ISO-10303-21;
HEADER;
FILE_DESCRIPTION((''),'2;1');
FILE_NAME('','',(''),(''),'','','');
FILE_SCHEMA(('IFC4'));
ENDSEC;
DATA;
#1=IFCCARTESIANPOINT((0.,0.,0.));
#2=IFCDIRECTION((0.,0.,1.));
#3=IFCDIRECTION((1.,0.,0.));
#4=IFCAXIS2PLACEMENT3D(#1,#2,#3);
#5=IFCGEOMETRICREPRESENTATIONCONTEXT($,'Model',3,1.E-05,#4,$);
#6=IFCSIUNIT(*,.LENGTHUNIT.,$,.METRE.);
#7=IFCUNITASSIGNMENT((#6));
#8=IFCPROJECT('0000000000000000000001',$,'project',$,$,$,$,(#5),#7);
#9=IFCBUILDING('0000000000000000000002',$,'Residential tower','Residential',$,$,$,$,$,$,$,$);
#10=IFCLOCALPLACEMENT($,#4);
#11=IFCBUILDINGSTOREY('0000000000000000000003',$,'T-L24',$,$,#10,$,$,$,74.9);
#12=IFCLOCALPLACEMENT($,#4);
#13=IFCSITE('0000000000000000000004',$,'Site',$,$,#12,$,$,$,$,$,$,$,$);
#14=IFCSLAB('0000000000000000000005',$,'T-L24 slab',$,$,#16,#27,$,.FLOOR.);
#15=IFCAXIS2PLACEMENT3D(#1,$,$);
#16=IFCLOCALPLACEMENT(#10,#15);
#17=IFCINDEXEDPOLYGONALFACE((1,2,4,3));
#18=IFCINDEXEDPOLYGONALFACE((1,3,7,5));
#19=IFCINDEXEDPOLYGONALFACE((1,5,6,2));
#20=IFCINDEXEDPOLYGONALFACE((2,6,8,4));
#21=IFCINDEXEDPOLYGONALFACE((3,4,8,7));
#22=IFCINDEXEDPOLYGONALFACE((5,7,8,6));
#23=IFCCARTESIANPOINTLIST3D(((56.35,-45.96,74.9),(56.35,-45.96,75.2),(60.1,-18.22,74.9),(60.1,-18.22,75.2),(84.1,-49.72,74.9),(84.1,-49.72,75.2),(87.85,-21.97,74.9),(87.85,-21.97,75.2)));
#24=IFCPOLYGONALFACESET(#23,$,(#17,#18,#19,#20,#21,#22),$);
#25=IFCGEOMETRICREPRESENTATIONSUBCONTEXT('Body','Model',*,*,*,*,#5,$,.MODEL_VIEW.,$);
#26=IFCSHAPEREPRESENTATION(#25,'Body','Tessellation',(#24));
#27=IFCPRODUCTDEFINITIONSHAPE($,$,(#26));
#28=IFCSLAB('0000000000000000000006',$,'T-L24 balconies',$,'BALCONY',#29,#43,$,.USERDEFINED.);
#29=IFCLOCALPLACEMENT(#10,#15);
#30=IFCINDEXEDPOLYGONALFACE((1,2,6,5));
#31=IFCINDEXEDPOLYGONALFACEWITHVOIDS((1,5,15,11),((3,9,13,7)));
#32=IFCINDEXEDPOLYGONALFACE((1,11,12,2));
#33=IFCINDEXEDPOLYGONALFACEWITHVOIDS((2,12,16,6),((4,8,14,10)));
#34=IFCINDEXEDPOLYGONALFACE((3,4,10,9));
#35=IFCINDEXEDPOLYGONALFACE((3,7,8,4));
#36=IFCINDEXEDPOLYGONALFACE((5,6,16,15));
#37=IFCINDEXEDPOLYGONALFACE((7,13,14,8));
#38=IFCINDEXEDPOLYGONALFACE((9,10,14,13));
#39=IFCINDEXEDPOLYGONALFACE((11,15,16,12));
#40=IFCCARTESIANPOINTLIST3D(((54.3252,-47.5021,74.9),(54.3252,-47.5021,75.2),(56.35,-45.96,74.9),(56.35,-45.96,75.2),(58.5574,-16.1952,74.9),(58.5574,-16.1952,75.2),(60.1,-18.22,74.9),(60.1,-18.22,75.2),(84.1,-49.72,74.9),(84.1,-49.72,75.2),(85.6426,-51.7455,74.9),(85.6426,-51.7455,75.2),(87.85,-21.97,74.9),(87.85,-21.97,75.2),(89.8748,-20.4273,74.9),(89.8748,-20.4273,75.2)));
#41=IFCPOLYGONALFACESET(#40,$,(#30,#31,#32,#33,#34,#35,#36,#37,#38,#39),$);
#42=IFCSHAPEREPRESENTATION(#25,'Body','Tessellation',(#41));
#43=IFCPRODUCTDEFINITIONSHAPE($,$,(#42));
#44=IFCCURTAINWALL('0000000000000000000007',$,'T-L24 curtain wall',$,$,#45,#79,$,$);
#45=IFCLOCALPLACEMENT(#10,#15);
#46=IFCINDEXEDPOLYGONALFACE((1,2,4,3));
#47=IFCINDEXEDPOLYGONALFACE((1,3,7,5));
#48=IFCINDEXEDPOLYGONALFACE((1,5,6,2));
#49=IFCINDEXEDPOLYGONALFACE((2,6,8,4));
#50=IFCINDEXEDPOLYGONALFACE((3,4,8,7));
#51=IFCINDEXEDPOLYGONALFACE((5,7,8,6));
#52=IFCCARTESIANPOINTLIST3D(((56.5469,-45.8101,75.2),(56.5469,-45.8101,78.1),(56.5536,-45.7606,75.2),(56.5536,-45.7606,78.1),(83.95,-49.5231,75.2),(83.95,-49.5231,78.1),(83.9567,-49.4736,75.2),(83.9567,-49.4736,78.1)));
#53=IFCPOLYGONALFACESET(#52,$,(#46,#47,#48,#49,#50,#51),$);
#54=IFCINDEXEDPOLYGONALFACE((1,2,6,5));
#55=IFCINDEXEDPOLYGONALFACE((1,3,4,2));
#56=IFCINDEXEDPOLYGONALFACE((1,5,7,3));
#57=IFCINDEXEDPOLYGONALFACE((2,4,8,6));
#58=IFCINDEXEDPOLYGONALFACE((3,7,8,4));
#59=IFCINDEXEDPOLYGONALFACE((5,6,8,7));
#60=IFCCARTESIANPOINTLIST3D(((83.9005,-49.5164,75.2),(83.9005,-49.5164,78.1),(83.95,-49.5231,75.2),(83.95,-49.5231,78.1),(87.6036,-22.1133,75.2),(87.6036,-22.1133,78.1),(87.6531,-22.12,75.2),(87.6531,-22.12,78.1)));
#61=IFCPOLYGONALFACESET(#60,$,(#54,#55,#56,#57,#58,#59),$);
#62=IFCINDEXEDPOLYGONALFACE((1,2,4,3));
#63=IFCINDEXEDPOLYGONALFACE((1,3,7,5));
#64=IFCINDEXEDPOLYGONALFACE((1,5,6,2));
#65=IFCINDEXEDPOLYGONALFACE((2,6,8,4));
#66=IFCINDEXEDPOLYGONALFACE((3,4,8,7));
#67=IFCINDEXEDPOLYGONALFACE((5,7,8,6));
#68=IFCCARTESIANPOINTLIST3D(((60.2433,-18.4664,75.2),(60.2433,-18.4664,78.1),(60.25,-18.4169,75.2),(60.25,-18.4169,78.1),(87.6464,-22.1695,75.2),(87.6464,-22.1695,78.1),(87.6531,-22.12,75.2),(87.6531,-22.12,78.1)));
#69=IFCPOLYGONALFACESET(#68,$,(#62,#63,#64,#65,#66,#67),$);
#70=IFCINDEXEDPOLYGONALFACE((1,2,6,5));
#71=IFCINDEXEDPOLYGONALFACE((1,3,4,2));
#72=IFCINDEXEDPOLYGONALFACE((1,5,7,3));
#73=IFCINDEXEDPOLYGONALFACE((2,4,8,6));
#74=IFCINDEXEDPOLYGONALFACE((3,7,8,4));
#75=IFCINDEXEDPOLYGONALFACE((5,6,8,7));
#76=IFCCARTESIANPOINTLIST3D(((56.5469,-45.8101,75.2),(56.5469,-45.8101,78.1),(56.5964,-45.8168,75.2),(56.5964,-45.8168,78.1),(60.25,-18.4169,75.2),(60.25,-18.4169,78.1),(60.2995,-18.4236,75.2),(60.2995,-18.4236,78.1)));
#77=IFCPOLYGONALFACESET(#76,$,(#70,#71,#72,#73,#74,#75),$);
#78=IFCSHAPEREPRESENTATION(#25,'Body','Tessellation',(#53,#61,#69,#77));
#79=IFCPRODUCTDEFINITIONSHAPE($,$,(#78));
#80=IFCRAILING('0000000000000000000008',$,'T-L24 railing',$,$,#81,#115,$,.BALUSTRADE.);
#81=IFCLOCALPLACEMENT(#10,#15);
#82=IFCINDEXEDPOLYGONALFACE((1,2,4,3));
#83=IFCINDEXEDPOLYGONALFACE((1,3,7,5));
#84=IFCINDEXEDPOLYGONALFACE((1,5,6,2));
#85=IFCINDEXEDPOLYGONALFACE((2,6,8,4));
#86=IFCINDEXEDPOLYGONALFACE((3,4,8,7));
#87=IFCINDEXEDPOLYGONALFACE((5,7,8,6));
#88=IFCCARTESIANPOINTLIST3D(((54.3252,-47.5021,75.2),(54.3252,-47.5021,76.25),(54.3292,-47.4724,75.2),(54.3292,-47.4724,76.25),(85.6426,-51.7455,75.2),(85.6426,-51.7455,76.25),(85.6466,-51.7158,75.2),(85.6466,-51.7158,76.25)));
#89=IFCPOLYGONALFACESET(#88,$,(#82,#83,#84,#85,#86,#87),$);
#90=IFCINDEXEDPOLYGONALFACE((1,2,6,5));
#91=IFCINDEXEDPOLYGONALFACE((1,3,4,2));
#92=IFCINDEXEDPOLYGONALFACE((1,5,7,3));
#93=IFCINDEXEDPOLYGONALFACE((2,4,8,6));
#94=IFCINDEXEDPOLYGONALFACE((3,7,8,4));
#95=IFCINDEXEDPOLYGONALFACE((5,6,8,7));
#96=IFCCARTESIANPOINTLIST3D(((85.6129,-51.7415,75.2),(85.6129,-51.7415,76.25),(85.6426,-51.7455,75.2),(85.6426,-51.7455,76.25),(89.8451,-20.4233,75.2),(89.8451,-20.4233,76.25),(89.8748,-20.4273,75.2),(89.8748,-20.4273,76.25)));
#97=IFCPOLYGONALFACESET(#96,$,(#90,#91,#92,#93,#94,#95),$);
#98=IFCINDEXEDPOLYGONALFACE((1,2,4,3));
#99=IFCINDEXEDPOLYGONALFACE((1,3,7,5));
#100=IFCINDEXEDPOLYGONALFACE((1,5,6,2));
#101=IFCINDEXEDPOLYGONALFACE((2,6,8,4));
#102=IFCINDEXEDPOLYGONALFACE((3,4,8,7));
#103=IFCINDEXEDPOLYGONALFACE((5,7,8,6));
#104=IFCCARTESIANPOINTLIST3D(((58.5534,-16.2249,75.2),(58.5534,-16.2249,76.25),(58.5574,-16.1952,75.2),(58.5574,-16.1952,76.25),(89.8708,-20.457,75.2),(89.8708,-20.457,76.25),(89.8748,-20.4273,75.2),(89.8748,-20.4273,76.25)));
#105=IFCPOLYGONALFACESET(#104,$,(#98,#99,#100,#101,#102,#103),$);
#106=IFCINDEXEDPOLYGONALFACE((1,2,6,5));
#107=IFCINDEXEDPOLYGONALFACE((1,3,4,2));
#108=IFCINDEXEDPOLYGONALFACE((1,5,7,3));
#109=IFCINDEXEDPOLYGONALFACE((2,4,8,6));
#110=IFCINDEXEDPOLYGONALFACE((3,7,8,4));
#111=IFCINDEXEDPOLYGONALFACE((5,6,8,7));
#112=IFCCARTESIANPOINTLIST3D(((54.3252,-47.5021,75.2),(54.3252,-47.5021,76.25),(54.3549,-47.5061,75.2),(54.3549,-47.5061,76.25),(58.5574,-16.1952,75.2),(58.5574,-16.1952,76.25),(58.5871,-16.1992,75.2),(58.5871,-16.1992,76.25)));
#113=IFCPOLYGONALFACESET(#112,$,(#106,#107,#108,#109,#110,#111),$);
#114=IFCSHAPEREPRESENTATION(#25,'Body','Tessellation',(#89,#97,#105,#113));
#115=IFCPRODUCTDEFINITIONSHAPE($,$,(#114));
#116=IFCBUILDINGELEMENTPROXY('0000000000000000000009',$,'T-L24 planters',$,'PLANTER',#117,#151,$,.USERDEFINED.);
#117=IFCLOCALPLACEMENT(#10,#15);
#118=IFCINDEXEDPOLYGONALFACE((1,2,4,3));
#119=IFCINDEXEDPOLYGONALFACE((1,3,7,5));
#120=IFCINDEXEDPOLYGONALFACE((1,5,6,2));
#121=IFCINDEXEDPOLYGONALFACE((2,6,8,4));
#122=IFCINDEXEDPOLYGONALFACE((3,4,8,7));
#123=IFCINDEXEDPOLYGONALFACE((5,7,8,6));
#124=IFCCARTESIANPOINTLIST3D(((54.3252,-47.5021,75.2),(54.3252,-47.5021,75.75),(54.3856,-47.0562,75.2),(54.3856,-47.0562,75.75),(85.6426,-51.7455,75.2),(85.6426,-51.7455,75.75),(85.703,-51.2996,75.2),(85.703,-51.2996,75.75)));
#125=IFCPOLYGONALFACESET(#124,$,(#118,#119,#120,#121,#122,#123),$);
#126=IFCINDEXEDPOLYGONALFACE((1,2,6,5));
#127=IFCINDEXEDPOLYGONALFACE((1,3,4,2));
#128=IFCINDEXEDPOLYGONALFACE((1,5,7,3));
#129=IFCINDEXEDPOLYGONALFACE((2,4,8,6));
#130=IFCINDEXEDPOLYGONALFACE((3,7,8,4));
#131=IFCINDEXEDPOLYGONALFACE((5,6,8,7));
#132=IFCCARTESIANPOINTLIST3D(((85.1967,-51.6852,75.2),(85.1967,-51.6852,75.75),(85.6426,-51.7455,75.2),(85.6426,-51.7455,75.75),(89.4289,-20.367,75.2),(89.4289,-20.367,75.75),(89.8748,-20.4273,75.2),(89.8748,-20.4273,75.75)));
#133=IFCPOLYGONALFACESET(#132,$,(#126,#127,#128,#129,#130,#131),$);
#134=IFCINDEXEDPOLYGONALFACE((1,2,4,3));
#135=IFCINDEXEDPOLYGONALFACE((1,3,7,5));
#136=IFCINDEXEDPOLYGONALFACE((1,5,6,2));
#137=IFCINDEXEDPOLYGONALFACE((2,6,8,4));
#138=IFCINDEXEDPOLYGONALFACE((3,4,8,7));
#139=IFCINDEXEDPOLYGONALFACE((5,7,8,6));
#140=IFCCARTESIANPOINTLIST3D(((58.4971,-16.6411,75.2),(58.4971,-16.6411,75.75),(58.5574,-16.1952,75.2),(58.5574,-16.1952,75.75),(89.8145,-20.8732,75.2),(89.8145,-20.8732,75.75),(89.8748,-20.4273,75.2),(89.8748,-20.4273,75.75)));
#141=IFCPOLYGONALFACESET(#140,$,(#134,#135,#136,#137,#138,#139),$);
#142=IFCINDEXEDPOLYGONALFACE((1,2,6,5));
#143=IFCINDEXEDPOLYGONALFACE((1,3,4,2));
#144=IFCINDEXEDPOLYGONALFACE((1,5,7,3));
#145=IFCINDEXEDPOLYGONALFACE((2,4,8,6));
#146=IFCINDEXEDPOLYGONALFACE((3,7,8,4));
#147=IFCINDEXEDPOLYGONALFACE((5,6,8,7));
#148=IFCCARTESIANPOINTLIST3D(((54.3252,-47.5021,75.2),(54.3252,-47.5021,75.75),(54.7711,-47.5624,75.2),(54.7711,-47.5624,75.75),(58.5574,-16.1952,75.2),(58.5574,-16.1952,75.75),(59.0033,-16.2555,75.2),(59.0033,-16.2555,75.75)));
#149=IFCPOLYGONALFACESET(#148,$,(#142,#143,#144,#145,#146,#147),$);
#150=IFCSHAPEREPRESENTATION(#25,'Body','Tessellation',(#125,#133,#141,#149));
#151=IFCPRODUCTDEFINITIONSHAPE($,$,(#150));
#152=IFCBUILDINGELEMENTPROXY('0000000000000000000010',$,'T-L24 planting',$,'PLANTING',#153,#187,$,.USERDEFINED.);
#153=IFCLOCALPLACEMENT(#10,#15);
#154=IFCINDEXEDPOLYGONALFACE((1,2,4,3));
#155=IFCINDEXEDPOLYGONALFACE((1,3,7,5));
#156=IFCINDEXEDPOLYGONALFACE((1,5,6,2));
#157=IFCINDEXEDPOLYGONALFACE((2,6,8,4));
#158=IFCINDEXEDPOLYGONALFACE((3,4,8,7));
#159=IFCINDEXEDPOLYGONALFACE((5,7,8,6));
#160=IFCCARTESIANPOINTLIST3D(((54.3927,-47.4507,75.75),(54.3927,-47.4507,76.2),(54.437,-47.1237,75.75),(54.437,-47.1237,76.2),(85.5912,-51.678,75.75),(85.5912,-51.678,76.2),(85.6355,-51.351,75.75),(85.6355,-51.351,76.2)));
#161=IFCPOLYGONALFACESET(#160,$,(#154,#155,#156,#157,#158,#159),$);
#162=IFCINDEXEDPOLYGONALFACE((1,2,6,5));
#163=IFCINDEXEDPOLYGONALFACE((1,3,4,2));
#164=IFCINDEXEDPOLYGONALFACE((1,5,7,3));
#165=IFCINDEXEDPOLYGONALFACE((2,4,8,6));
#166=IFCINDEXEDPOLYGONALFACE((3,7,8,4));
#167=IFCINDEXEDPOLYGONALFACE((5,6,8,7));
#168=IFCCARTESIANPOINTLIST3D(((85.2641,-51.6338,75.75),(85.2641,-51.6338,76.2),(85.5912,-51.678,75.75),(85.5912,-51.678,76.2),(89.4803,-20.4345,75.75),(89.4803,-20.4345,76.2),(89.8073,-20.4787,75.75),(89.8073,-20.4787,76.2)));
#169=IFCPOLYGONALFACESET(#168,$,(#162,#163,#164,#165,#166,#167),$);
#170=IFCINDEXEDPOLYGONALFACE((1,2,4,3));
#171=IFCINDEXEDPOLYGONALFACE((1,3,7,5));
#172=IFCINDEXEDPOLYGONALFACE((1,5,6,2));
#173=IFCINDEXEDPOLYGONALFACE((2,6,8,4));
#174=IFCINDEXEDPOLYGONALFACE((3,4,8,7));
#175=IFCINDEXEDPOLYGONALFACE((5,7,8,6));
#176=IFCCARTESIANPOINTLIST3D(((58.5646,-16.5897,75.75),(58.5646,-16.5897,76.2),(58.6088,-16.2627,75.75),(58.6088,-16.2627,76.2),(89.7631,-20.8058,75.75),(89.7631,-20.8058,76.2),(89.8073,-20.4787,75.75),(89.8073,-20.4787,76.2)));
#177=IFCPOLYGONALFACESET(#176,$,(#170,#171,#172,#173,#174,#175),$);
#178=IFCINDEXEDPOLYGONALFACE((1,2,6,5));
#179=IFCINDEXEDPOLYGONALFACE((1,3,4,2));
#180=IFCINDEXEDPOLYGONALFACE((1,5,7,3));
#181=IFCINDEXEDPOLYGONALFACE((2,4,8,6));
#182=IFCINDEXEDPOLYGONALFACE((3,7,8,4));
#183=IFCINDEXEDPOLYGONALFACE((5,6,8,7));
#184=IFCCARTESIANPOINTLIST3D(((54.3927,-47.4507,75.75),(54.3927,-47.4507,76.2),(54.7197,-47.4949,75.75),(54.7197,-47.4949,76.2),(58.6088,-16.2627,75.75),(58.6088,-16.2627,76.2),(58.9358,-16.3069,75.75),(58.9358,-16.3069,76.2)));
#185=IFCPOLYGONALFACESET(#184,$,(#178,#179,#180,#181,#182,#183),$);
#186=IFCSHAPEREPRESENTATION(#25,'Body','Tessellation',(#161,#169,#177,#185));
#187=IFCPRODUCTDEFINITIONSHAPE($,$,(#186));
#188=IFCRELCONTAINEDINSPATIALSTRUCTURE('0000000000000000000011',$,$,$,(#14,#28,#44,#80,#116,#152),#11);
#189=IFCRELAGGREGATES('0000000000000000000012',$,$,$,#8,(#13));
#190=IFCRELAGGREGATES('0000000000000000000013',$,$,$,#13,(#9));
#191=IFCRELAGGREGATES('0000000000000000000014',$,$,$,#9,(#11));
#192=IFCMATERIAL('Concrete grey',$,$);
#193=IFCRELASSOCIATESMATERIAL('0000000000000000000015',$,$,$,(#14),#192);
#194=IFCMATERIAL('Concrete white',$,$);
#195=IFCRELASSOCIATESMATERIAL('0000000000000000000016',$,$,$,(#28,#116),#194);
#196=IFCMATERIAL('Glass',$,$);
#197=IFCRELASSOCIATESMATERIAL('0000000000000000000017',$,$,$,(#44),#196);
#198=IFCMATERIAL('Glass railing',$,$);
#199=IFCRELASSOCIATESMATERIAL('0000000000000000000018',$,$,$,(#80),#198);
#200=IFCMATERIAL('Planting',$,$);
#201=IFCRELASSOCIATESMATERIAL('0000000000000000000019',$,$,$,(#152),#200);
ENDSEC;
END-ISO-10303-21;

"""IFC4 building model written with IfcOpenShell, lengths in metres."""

from ifc_helpers import new_model, si_unit, frame, origin_with_axes, place, context, subcontext, project, spatial, polyline, outline, extrude, material, element, save


model = new_model("IFC4")

# Units and contexts
model_context = context("Model", 3, precision=1e-05, world=origin_with_axes())
body_context = subcontext(model_context, "Body", "Model", "MODEL_VIEW")
ifc_project = project(units=[si_unit("LENGTHUNIT", "METRE")], contexts=[model_context])

# Site, building, storey
site_placement = place(None, origin_with_axes())
site = spatial("IfcSite", under=ifc_project, at=site_placement, Name="Site")
building = spatial("IfcBuilding", under=site, Name="Residential tower", Description="Residential")
storey_placement = place(None, origin_with_axes())
storey = spatial("IfcBuildingStorey", under=building, at=storey_placement, Name="T-L24", Elevation=74.9)

# Slabs
ifc_material_1 = material(Name="Concrete grey")
slab_1_placement = place(storey_placement, origin_with_axes())
element("IfcSlab", 1, at=slab_1_placement, inside=storey, material=ifc_material_1, Name="T-L24 slab", PredefinedType="FLOOR", context=body_context, shape_type="SweptSolid", body=[
    extrude(outline(polyline([(56.35, -45.96), (84.1, -49.72), (87.85, -21.97), (60.1, -18.22), (56.35, -45.96)])), frame((0.0, 0.0, 74.9), z_axis=(0.0, 0.0, 1.0), x_axis=(1.0, 0.0, 0.0)), (0.0, 0.0, 1.0), 0.3),
])
ifc_material_2 = material(Name="Concrete white")
slab_2_placement = place(storey_placement, origin_with_axes())
element("IfcSlab", 2, at=slab_2_placement, inside=storey, material=ifc_material_2, Name="T-L24 balconies", ObjectType="BALCONY", PredefinedType="USERDEFINED", context=body_context, shape_type="SweptSolid", body=[
    extrude(outline(polyline([(54.3252, -47.5021), (85.6426, -51.7455), (89.8748, -20.4273), (58.5574, -16.1952), (54.3252, -47.5021)]), holes=[polyline([(56.35, -45.96), (84.1, -49.72), (87.85, -21.97), (60.1, -18.22), (56.35, -45.96)])]), frame((0.0, 0.0, 74.9), z_axis=(0.0, 0.0, 1.0), x_axis=(1.0, 0.0, 0.0)), (0.0, 0.0, 1.0), 0.3),
])

# Curtain wall
ifc_material_3 = material(Name="Glass")
curtain_wall_placement = place(storey_placement, origin_with_axes())
element("IfcCurtainWall", 3, at=curtain_wall_placement, inside=storey, material=ifc_material_3, Name="T-L24 curtain wall", context=body_context, shape_type="SweptSolid", body=[
    extrude(outline(polyline([(56.5469, -45.8101), (83.95, -49.5231), (83.9567, -49.4736), (56.5536, -45.7606), (56.5469, -45.8101)])), frame((0.0, 0.0, 75.2), z_axis=(0.0, 0.0, 1.0), x_axis=(1.0, 0.0, 0.0)), (0.0, 0.0, 1.0), 2.9),
    extrude(outline(polyline([(83.95, -49.5231), (87.6531, -22.12), (87.6036, -22.1133), (83.9005, -49.5164), (83.95, -49.5231)])), frame((0.0, 0.0, 75.2), z_axis=(0.0, 0.0, 1.0), x_axis=(1.0, 0.0, 0.0)), (0.0, 0.0, 1.0), 2.9),
    extrude(outline(polyline([(87.6531, -22.12), (60.25, -18.4169), (60.2433, -18.4664), (87.6464, -22.1695), (87.6531, -22.12)])), frame((0.0, 0.0, 75.2), z_axis=(0.0, 0.0, 1.0), x_axis=(1.0, 0.0, 0.0)), (0.0, 0.0, 1.0), 2.9),
    extrude(outline(polyline([(60.25, -18.4169), (56.5469, -45.8101), (56.5964, -45.8168), (60.2995, -18.4236), (60.25, -18.4169)])), frame((0.0, 0.0, 75.2), z_axis=(0.0, 0.0, 1.0), x_axis=(1.0, 0.0, 0.0)), (0.0, 0.0, 1.0), 2.9),
])

# Railing
ifc_material_4 = material(Name="Glass railing")
railing_placement = place(storey_placement, origin_with_axes())
element("IfcRailing", 4, at=railing_placement, inside=storey, material=ifc_material_4, Name="T-L24 railing", PredefinedType="BALUSTRADE", context=body_context, shape_type="SweptSolid", body=[
    extrude(outline(polyline([(54.3252, -47.5021), (85.6426, -51.7455), (85.6466, -51.7158), (54.3292, -47.4724), (54.3252, -47.5021)])), frame((0.0, 0.0, 75.2), z_axis=(0.0, 0.0, 1.0), x_axis=(1.0, 0.0, 0.0)), (0.0, 0.0, 1.0), 1.05),
    extrude(outline(polyline([(85.6426, -51.7455), (89.8748, -20.4273), (89.8451, -20.4233), (85.6129, -51.7415), (85.6426, -51.7455)])), frame((0.0, 0.0, 75.2), z_axis=(0.0, 0.0, 1.0), x_axis=(1.0, 0.0, 0.0)), (0.0, 0.0, 1.0), 1.05),
    extrude(outline(polyline([(89.8748, -20.4273), (58.5574, -16.1952), (58.5534, -16.2249), (89.8708, -20.457), (89.8748, -20.4273)])), frame((0.0, 0.0, 75.2), z_axis=(0.0, 0.0, 1.0), x_axis=(1.0, 0.0, 0.0)), (0.0, 0.0, 1.0), 1.05),
    extrude(outline(polyline([(58.5574, -16.1952), (54.3252, -47.5021), (54.3549, -47.5061), (58.5871, -16.1992), (58.5574, -16.1952)])), frame((0.0, 0.0, 75.2), z_axis=(0.0, 0.0, 1.0), x_axis=(1.0, 0.0, 0.0)), (0.0, 0.0, 1.0), 1.05),
])

# Building element proxies
proxy_1_placement = place(storey_placement, origin_with_axes())
element("IfcBuildingElementProxy", 5, at=proxy_1_placement, inside=storey, material=ifc_material_2, Name="T-L24 planters", ObjectType="PLANTER", PredefinedType="USERDEFINED", context=body_context, shape_type="SweptSolid", body=[
    extrude(outline(polyline([(54.3252, -47.5021), (85.6426, -51.7455), (85.703, -51.2996), (54.3856, -47.0562), (54.3252, -47.5021)])), frame((0.0, 0.0, 75.2), z_axis=(0.0, 0.0, 1.0), x_axis=(1.0, 0.0, 0.0)), (0.0, 0.0, 1.0), 0.55),
    extrude(outline(polyline([(85.6426, -51.7455), (89.8748, -20.4273), (89.4289, -20.367), (85.1967, -51.6852), (85.6426, -51.7455)])), frame((0.0, 0.0, 75.2), z_axis=(0.0, 0.0, 1.0), x_axis=(1.0, 0.0, 0.0)), (0.0, 0.0, 1.0), 0.55),
    extrude(outline(polyline([(89.8748, -20.4273), (58.5574, -16.1952), (58.4971, -16.6411), (89.8145, -20.8732), (89.8748, -20.4273)])), frame((0.0, 0.0, 75.2), z_axis=(0.0, 0.0, 1.0), x_axis=(1.0, 0.0, 0.0)), (0.0, 0.0, 1.0), 0.55),
    extrude(outline(polyline([(58.5574, -16.1952), (54.3252, -47.5021), (54.7711, -47.5624), (59.0033, -16.2555), (58.5574, -16.1952)])), frame((0.0, 0.0, 75.2), z_axis=(0.0, 0.0, 1.0), x_axis=(1.0, 0.0, 0.0)), (0.0, 0.0, 1.0), 0.55),
])
ifc_material_5 = material(Name="Planting")
proxy_2_placement = place(storey_placement, origin_with_axes())
element("IfcBuildingElementProxy", 6, at=proxy_2_placement, inside=storey, material=ifc_material_5, Name="T-L24 planting", ObjectType="PLANTING", PredefinedType="USERDEFINED", context=body_context, shape_type="SweptSolid", body=[
    extrude(outline(polyline([(54.3927, -47.4507), (85.5912, -51.678), (85.6355, -51.351), (54.437, -47.1237), (54.3927, -47.4507)])), frame((0.0, 0.0, 75.75), z_axis=(0.0, 0.0, 1.0), x_axis=(1.0, 0.0, 0.0)), (0.0, 0.0, 1.0), 0.45),
    extrude(outline(polyline([(85.5912, -51.678), (89.8073, -20.4787), (89.4803, -20.4345), (85.2641, -51.6338), (85.5912, -51.678)])), frame((0.0, 0.0, 75.75), z_axis=(0.0, 0.0, 1.0), x_axis=(1.0, 0.0, 0.0)), (0.0, 0.0, 1.0), 0.45),
    extrude(outline(polyline([(89.8073, -20.4787), (58.6088, -16.2627), (58.5646, -16.5897), (89.7631, -20.8058), (89.8073, -20.4787)])), frame((0.0, 0.0, 75.75), z_axis=(0.0, 0.0, 1.0), x_axis=(1.0, 0.0, 0.0)), (0.0, 0.0, 1.0), 0.45),
    extrude(outline(polyline([(58.6088, -16.2627), (54.3927, -47.4507), (54.7197, -47.4949), (58.9358, -16.3069), (58.6088, -16.2627)])), frame((0.0, 0.0, 75.75), z_axis=(0.0, 0.0, 1.0), x_axis=(1.0, 0.0, 0.0)), (0.0, 0.0, 1.0), 0.45),
])

save(model, "model.ifc")
